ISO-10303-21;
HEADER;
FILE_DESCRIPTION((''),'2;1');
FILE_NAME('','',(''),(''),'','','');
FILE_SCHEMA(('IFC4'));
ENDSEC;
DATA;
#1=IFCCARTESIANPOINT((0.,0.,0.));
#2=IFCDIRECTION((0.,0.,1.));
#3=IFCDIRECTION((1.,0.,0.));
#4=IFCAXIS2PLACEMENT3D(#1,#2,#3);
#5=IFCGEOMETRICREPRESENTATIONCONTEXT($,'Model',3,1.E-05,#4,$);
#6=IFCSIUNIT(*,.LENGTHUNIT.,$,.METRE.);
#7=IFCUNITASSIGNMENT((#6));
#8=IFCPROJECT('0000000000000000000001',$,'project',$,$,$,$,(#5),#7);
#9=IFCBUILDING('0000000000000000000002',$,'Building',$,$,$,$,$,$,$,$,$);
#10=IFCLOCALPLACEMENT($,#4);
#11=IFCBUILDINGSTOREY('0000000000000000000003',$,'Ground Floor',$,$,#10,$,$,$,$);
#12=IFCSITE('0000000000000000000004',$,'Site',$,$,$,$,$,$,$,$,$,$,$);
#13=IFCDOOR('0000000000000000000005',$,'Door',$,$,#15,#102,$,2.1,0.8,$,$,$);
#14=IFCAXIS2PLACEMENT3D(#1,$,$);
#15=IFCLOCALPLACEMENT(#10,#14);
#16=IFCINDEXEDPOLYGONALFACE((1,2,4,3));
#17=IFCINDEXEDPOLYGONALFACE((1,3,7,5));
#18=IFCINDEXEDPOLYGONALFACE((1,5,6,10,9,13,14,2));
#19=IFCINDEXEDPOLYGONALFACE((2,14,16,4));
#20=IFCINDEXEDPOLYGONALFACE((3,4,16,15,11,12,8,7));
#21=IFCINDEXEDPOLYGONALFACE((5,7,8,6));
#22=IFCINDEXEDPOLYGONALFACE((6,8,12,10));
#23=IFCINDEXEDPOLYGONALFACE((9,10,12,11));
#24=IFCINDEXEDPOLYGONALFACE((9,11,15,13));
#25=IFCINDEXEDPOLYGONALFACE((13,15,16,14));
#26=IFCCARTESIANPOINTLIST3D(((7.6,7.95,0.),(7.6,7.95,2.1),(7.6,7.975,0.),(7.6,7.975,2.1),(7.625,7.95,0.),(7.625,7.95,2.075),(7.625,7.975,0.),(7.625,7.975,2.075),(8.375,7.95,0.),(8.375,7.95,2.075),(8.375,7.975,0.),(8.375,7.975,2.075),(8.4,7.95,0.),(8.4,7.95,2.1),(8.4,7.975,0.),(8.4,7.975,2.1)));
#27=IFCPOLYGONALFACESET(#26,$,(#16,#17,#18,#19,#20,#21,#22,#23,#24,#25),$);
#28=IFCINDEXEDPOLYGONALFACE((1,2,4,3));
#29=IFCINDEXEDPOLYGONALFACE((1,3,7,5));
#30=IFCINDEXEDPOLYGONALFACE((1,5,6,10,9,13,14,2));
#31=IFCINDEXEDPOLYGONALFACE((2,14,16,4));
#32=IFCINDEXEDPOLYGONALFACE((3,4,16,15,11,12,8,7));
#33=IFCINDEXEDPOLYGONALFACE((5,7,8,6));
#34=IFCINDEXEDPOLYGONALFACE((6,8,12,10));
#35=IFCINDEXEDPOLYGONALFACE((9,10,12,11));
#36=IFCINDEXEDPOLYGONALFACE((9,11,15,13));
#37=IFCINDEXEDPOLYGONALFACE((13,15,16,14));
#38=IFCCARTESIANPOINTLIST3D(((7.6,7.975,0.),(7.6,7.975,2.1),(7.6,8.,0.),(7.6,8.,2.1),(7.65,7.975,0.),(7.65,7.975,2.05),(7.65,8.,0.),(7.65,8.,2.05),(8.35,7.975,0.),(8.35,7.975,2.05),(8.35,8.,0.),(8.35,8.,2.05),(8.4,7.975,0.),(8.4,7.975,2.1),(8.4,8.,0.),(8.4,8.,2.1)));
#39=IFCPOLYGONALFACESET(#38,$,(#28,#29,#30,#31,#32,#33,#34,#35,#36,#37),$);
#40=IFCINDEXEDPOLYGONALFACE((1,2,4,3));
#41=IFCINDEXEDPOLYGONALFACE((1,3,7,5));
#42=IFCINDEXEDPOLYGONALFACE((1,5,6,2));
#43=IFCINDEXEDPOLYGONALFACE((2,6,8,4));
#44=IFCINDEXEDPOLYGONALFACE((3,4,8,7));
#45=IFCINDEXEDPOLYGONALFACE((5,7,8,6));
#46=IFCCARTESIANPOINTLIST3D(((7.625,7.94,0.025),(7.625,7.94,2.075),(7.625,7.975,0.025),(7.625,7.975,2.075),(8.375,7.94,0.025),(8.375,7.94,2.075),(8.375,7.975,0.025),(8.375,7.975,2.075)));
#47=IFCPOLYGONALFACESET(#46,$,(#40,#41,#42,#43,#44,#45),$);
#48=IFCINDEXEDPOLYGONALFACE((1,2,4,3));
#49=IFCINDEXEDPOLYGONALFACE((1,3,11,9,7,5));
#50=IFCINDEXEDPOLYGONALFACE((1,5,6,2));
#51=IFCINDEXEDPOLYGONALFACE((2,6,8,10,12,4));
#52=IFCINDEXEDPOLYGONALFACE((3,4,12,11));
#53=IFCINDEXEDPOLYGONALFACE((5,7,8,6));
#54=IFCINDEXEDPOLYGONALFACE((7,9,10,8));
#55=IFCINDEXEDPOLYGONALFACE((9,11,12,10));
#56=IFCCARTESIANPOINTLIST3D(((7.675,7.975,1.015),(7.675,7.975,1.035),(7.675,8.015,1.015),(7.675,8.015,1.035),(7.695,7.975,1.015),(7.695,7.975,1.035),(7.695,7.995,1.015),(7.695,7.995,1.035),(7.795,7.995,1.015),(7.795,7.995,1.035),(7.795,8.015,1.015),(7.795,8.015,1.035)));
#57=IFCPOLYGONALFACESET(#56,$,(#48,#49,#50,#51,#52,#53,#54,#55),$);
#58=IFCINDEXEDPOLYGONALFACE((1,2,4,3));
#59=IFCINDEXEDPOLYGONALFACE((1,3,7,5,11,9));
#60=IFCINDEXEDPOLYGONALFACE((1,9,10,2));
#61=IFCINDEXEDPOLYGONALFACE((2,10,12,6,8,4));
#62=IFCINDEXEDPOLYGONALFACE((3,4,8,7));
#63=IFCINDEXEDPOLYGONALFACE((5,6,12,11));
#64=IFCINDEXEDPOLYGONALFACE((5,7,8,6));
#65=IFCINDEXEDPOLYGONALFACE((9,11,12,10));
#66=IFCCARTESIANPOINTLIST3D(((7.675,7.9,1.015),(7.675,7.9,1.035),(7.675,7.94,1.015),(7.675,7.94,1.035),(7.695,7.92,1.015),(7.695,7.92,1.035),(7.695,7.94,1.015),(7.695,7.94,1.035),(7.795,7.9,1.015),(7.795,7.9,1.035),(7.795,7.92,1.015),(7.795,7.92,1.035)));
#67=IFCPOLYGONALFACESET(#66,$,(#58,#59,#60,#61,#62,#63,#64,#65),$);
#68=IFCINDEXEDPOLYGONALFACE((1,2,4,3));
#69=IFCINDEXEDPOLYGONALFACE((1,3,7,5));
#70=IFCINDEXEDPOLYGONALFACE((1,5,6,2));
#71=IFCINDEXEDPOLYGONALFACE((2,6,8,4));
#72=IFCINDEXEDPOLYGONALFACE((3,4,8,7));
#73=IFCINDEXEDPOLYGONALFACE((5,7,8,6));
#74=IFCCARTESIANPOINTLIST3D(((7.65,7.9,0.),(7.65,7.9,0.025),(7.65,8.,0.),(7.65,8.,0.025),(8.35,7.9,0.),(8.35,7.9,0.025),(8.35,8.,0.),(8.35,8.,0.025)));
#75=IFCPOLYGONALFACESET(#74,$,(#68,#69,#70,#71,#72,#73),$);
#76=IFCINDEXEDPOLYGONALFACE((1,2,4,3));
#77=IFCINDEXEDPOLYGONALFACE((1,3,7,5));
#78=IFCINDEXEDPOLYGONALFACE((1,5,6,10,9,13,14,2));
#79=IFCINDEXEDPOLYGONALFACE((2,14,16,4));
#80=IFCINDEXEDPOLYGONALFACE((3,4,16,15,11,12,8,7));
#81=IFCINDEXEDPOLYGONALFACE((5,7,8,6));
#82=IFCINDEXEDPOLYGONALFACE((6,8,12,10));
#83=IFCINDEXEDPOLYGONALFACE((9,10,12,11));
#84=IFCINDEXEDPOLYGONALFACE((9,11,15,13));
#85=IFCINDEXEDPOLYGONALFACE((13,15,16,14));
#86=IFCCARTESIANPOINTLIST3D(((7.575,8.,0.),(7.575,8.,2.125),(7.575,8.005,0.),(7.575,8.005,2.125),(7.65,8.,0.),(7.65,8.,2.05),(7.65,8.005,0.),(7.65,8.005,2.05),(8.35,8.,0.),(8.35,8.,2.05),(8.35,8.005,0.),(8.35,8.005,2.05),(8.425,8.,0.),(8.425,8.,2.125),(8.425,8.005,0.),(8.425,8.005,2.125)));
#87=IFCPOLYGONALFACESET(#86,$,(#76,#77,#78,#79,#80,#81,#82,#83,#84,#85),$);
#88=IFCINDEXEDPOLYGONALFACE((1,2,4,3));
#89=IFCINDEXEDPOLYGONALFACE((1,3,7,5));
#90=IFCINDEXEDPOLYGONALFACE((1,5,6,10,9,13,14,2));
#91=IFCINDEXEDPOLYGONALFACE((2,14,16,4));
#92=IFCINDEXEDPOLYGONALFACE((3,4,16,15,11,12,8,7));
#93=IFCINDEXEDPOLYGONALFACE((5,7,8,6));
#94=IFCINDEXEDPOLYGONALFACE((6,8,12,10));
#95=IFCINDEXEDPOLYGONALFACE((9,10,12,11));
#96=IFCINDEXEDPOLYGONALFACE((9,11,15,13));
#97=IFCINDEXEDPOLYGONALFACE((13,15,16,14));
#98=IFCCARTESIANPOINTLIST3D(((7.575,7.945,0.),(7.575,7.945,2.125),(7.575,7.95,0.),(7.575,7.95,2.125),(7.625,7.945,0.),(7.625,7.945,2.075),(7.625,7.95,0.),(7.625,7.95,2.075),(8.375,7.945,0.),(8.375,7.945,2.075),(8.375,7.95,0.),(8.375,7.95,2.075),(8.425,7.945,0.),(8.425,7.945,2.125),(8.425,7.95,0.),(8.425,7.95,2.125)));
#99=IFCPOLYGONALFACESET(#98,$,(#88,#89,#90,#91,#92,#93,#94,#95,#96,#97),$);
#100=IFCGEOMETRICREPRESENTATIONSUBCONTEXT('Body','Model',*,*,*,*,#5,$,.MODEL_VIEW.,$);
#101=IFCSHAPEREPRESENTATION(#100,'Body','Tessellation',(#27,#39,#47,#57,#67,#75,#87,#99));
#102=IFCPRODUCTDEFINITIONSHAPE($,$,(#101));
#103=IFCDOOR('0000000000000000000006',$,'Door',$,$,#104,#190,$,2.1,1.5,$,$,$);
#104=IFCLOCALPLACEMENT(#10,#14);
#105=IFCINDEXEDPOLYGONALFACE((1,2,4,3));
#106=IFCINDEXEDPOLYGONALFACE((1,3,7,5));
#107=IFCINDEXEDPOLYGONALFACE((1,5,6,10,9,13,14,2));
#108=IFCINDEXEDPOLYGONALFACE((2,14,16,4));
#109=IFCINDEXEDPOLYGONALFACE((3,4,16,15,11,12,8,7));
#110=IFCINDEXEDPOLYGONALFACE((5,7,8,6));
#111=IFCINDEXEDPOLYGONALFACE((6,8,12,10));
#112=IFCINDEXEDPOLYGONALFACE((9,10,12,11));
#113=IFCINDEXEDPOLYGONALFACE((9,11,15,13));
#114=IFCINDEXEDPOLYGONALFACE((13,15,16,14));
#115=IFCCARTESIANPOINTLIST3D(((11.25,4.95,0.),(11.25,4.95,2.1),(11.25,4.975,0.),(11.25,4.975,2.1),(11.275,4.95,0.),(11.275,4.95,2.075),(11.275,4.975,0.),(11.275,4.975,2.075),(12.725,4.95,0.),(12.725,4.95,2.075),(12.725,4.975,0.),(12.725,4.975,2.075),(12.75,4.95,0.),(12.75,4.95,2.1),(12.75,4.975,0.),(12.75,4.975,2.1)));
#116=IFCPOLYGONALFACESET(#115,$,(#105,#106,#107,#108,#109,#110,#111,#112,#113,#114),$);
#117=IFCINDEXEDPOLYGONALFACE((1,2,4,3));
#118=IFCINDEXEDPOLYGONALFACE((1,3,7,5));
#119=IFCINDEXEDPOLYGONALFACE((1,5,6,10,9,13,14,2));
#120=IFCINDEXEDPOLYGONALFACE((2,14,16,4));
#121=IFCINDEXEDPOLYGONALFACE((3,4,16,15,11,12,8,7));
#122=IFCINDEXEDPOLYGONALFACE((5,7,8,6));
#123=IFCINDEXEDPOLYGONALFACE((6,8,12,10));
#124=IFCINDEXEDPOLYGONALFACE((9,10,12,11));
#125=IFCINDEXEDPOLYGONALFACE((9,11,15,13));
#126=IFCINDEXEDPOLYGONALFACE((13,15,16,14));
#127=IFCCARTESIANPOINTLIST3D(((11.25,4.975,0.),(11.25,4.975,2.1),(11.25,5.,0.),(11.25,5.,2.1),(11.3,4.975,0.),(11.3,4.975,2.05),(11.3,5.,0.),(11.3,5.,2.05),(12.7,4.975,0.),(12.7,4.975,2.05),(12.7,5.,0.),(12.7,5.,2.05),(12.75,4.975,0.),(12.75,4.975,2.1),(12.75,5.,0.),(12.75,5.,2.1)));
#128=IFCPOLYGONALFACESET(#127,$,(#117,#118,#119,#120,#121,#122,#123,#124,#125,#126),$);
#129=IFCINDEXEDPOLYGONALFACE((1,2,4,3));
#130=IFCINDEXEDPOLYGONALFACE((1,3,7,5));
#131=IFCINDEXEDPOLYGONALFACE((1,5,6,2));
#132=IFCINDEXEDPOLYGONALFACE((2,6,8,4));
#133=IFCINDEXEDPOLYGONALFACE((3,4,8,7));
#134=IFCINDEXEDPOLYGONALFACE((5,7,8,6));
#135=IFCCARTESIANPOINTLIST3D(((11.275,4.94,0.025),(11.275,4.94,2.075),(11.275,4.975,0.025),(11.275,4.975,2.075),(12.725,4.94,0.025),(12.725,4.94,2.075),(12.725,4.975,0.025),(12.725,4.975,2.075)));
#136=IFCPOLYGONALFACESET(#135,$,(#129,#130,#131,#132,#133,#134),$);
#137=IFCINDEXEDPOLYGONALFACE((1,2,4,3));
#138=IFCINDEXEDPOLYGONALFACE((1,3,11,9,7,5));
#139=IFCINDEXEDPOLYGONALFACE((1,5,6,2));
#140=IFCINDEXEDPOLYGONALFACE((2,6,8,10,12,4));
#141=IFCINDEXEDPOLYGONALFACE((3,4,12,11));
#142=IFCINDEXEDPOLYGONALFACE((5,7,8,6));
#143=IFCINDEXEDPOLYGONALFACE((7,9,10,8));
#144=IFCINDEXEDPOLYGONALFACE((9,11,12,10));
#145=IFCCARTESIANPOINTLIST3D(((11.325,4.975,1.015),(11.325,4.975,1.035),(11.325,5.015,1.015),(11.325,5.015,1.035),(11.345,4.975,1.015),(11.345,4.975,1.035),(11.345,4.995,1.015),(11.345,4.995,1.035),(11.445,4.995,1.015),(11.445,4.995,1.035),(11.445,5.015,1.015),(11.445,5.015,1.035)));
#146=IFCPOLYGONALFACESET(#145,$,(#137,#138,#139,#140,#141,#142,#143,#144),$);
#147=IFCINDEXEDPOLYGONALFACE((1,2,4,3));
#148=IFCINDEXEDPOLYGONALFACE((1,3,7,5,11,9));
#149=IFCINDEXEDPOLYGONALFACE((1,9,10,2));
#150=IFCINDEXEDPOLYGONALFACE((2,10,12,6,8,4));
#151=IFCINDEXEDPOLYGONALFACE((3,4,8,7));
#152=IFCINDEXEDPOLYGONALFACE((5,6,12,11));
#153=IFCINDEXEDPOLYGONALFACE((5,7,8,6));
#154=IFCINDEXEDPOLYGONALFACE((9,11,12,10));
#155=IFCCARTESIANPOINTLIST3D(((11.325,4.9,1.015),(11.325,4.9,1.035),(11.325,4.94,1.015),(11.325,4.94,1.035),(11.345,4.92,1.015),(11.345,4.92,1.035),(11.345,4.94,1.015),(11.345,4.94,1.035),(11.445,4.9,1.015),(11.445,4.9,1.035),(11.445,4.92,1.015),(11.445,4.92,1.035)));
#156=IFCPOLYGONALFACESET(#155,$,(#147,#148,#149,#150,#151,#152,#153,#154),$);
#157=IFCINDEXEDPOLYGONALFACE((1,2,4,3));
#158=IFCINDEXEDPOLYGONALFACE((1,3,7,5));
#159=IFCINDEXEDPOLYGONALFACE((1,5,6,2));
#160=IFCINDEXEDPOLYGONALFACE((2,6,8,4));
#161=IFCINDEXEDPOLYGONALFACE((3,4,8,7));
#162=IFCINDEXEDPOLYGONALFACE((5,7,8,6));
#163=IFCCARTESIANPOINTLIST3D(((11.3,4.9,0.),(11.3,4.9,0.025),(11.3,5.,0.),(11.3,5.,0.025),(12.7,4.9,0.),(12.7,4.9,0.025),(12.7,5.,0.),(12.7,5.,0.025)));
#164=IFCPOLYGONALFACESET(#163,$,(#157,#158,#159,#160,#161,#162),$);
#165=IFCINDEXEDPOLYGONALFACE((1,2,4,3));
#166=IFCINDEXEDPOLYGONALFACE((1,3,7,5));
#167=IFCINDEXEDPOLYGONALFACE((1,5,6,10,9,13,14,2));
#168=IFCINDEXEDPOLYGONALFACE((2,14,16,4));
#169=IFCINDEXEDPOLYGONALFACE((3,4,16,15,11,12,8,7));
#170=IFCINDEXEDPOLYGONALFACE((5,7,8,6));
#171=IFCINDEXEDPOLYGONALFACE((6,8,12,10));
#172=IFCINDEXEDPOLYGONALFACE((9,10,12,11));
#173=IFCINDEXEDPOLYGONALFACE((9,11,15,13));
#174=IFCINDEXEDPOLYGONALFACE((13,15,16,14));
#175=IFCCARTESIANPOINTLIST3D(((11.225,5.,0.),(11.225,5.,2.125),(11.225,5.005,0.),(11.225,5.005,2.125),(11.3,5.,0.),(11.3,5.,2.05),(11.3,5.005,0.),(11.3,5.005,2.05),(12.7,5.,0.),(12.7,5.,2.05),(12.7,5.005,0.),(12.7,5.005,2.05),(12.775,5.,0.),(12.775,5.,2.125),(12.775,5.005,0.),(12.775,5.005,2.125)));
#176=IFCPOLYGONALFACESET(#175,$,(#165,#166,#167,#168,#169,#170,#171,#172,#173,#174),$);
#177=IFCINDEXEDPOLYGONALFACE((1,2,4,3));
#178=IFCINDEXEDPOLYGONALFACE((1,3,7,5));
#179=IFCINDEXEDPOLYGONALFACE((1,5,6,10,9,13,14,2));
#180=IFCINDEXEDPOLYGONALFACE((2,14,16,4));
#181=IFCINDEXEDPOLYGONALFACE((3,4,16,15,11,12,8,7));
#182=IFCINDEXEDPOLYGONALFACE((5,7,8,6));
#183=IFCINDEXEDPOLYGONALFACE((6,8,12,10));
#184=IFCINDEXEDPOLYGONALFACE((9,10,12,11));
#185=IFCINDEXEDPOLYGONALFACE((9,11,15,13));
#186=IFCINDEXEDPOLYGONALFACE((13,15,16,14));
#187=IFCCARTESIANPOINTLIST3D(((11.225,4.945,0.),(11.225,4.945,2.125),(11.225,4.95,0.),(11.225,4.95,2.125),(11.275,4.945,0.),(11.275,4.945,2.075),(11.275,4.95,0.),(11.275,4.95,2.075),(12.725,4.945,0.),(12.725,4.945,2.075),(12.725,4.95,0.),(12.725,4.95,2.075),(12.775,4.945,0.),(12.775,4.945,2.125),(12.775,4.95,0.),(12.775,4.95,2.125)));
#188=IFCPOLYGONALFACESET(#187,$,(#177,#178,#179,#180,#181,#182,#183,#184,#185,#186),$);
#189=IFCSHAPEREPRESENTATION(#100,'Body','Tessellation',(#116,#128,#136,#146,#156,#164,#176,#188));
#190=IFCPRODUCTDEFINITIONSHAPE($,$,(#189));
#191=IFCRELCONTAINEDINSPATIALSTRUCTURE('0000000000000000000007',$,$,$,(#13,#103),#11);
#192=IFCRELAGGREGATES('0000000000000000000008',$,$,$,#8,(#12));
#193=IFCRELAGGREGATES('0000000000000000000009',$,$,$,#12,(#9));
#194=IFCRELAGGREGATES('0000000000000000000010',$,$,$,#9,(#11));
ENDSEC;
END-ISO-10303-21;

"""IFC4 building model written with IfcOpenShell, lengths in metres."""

from ifc_helpers import new_model, si_unit, frame, origin_with_axes, place, context, subcontext, project, spatial, line, indexed_curve, outline, extrude, element, save


model = new_model("IFC4")

# Units and contexts
model_context = context("Model", 3, precision=1e-05, world=origin_with_axes())
body_context = subcontext(model_context, "Body", "Model", "MODEL_VIEW")
ifc_project = project(units=[si_unit("LENGTHUNIT", "METRE")], contexts=[model_context])

# Site, building, storey
site = spatial("IfcSite", under=ifc_project, Name="Site")
building = spatial("IfcBuilding", under=site, Name="Building")
storey_placement = place(None, origin_with_axes())
storey = spatial("IfcBuildingStorey", under=building, at=storey_placement, Name="Ground Floor")

# Doors
door_1_placement = place(storey_placement, frame((8.4, 8.0, 0.0), z_axis=(0.0, 0.0, 1.0), x_axis=(-1.0, 0.0, 0.0)))
element("IfcDoor", 1, at=door_1_placement, inside=storey, Name="Door", OverallHeight=2.1, OverallWidth=0.8, context=body_context, shape_type="SweptSolid", body=[
    extrude(outline(indexed_curve([(0.0, 0.0), (0.0, 2.1), (0.8, 2.1), (0.8, 0.0), (0.775, 0.0), (0.775, 2.075), (0.025, 2.075), (0.025, 0.0)], segments=[line(1, 2, 3, 4, 5, 6, 7, 8, 1)])), frame((0.0, 0.025, 0.0), z_axis=(0.0, -1.0, 0.0), x_axis=(1.0, 0.0, 0.0)), (0.0, 0.0, -1.0), 0.025),
    extrude(outline(indexed_curve([(0.0, 0.0), (0.0, 2.1), (0.8, 2.1), (0.8, 0.0), (0.75, 0.0), (0.75, 2.05), (0.05, 2.05), (0.05, 0.0)], segments=[line(1, 2, 3, 4, 5, 6, 7, 8, 1)])), frame((0.0, 0.0, 0.0), z_axis=(0.0, -1.0, 0.0), x_axis=(1.0, 0.0, 0.0)), (0.0, 0.0, -1.0), 0.025),
    extrude(outline(indexed_curve([(0.0, 0.0), (0.75, 0.0), (0.75, 0.035), (0.0, 0.035)], segments=[line(1, 2, 3, 4, 1)])), frame((0.025, 0.025, 0.025), z_axis=(0.0, 0.0, 1.0), x_axis=(1.0, 0.0, 0.0)), (0.0, 0.0, 1.0), 2.05),
    extrude(outline(indexed_curve([(0.0, 0.0), (0.0, -0.04), (-0.12, -0.04), (-0.12, -0.02), (-0.02, -0.02), (-0.02, 0.0)], segments=[line(1, 2, 3, 4, 5, 6, 1)])), frame((0.725, 0.025, 1.015), z_axis=(0.0, 0.0, 1.0), x_axis=(1.0, 0.0, 0.0)), (0.0, 0.0, 1.0), 0.02),
    extrude(outline(indexed_curve([(0.0, 0.0), (0.0, 0.04), (-0.12, 0.04), (-0.12, 0.02), (-0.02, 0.02), (-0.02, 0.0)], segments=[line(1, 2, 3, 4, 5, 6, 1)])), frame((0.725, 0.06, 1.015), z_axis=(0.0, 0.0, 1.0), x_axis=(1.0, 0.0, 0.0)), (0.0, 0.0, 1.0), 0.02),
    extrude(outline(indexed_curve([(0.0, 0.0), (0.7, 0.0), (0.7, 0.1), (0.0, 0.1)], segments=[line(1, 2, 3, 4, 1)])), frame((0.05, 0.0, 0.0), z_axis=(0.0, 0.0, 1.0), x_axis=(1.0, 0.0, 0.0)), (0.0, 0.0, 1.0), 0.025),
    extrude(outline(indexed_curve([(0.0, 0.0), (0.0, 2.125), (0.85, 2.125), (0.85, 0.0), (0.775, 0.0), (0.775, 2.05), (0.075, 2.05), (0.075, 0.0)], segments=[line(1, 2, 3, 4, 5, 6, 7, 8, 1)])), frame((-0.025, -0.005, 0.0), z_axis=(0.0, -1.0, 0.0), x_axis=(1.0, 0.0, 0.0)), (0.0, 0.0, -1.0), 0.005),
    extrude(outline(indexed_curve([(0.0, 0.0), (0.0, 2.125), (0.85, 2.125), (0.85, 0.0), (0.8, 0.0), (0.8, 2.075), (0.05, 2.075), (0.05, 0.0)], segments=[line(1, 2, 3, 4, 5, 6, 7, 8, 1)])), frame((-0.025, 0.05, 0.0), z_axis=(0.0, -1.0, 0.0), x_axis=(1.0, 0.0, 0.0)), (0.0, 0.0, -1.0), 0.005),
])
door_2_placement = place(storey_placement, frame((12.75, 5.0, 0.0), z_axis=(0.0, 0.0, 1.0), x_axis=(-1.0, 0.0, 0.0)))
element("IfcDoor", 2, at=door_2_placement, inside=storey, Name="Door", OverallHeight=2.1, OverallWidth=1.5, context=body_context, shape_type="SweptSolid", body=[
    extrude(outline(indexed_curve([(0.0, 0.0), (0.0, 2.1), (1.5, 2.1), (1.5, 0.0), (1.475, 0.0), (1.475, 2.075), (0.025, 2.075), (0.025, 0.0)], segments=[line(1, 2, 3, 4, 5, 6, 7, 8, 1)])), frame((0.0, 0.025, 0.0), z_axis=(0.0, -1.0, 0.0), x_axis=(1.0, 0.0, 0.0)), (0.0, 0.0, -1.0), 0.025),
    extrude(outline(indexed_curve([(0.0, 0.0), (0.0, 2.1), (1.5, 2.1), (1.5, 0.0), (1.45, 0.0), (1.45, 2.05), (0.05, 2.05), (0.05, 0.0)], segments=[line(1, 2, 3, 4, 5, 6, 7, 8, 1)])), frame((0.0, 0.0, 0.0), z_axis=(0.0, -1.0, 0.0), x_axis=(1.0, 0.0, 0.0)), (0.0, 0.0, -1.0), 0.025),
    extrude(outline(indexed_curve([(0.0, 0.0), (1.45, 0.0), (1.45, 0.035), (0.0, 0.035)], segments=[line(1, 2, 3, 4, 1)])), frame((0.025, 0.025, 0.025), z_axis=(0.0, 0.0, 1.0), x_axis=(1.0, 0.0, 0.0)), (0.0, 0.0, 1.0), 2.05),
    extrude(outline(indexed_curve([(0.0, 0.0), (0.0, -0.04), (-0.12, -0.04), (-0.12, -0.02), (-0.02, -0.02), (-0.02, 0.0)], segments=[line(1, 2, 3, 4, 5, 6, 1)])), frame((1.425, 0.025, 1.015), z_axis=(0.0, 0.0, 1.0), x_axis=(1.0, 0.0, 0.0)), (0.0, 0.0, 1.0), 0.02),
    extrude(outline(indexed_curve([(0.0, 0.0), (0.0, 0.04), (-0.12, 0.04), (-0.12, 0.02), (-0.02, 0.02), (-0.02, 0.0)], segments=[line(1, 2, 3, 4, 5, 6, 1)])), frame((1.425, 0.06, 1.015), z_axis=(0.0, 0.0, 1.0), x_axis=(1.0, 0.0, 0.0)), (0.0, 0.0, 1.0), 0.02),
    extrude(outline(indexed_curve([(0.0, 0.0), (1.4, 0.0), (1.4, 0.1), (0.0, 0.1)], segments=[line(1, 2, 3, 4, 1)])), frame((0.05, 0.0, 0.0), z_axis=(0.0, 0.0, 1.0), x_axis=(1.0, 0.0, 0.0)), (0.0, 0.0, 1.0), 0.025),
    extrude(outline(indexed_curve([(0.0, 0.0), (0.0, 2.125), (1.55, 2.125), (1.55, 0.0), (1.475, 0.0), (1.475, 2.05), (0.075, 2.05), (0.075, 0.0)], segments=[line(1, 2, 3, 4, 5, 6, 7, 8, 1)])), frame((-0.025, -0.005, 0.0), z_axis=(0.0, -1.0, 0.0), x_axis=(1.0, 0.0, 0.0)), (0.0, 0.0, -1.0), 0.005),
    extrude(outline(indexed_curve([(0.0, 0.0), (0.0, 2.125), (1.55, 2.125), (1.55, 0.0), (1.5, 0.0), (1.5, 2.075), (0.05, 2.075), (0.05, 0.0)], segments=[line(1, 2, 3, 4, 5, 6, 7, 8, 1)])), frame((-0.025, 0.05, 0.0), z_axis=(0.0, -1.0, 0.0), x_axis=(1.0, 0.0, 0.0)), (0.0, 0.0, -1.0), 0.005),
])

save(model, "model.ifc")
